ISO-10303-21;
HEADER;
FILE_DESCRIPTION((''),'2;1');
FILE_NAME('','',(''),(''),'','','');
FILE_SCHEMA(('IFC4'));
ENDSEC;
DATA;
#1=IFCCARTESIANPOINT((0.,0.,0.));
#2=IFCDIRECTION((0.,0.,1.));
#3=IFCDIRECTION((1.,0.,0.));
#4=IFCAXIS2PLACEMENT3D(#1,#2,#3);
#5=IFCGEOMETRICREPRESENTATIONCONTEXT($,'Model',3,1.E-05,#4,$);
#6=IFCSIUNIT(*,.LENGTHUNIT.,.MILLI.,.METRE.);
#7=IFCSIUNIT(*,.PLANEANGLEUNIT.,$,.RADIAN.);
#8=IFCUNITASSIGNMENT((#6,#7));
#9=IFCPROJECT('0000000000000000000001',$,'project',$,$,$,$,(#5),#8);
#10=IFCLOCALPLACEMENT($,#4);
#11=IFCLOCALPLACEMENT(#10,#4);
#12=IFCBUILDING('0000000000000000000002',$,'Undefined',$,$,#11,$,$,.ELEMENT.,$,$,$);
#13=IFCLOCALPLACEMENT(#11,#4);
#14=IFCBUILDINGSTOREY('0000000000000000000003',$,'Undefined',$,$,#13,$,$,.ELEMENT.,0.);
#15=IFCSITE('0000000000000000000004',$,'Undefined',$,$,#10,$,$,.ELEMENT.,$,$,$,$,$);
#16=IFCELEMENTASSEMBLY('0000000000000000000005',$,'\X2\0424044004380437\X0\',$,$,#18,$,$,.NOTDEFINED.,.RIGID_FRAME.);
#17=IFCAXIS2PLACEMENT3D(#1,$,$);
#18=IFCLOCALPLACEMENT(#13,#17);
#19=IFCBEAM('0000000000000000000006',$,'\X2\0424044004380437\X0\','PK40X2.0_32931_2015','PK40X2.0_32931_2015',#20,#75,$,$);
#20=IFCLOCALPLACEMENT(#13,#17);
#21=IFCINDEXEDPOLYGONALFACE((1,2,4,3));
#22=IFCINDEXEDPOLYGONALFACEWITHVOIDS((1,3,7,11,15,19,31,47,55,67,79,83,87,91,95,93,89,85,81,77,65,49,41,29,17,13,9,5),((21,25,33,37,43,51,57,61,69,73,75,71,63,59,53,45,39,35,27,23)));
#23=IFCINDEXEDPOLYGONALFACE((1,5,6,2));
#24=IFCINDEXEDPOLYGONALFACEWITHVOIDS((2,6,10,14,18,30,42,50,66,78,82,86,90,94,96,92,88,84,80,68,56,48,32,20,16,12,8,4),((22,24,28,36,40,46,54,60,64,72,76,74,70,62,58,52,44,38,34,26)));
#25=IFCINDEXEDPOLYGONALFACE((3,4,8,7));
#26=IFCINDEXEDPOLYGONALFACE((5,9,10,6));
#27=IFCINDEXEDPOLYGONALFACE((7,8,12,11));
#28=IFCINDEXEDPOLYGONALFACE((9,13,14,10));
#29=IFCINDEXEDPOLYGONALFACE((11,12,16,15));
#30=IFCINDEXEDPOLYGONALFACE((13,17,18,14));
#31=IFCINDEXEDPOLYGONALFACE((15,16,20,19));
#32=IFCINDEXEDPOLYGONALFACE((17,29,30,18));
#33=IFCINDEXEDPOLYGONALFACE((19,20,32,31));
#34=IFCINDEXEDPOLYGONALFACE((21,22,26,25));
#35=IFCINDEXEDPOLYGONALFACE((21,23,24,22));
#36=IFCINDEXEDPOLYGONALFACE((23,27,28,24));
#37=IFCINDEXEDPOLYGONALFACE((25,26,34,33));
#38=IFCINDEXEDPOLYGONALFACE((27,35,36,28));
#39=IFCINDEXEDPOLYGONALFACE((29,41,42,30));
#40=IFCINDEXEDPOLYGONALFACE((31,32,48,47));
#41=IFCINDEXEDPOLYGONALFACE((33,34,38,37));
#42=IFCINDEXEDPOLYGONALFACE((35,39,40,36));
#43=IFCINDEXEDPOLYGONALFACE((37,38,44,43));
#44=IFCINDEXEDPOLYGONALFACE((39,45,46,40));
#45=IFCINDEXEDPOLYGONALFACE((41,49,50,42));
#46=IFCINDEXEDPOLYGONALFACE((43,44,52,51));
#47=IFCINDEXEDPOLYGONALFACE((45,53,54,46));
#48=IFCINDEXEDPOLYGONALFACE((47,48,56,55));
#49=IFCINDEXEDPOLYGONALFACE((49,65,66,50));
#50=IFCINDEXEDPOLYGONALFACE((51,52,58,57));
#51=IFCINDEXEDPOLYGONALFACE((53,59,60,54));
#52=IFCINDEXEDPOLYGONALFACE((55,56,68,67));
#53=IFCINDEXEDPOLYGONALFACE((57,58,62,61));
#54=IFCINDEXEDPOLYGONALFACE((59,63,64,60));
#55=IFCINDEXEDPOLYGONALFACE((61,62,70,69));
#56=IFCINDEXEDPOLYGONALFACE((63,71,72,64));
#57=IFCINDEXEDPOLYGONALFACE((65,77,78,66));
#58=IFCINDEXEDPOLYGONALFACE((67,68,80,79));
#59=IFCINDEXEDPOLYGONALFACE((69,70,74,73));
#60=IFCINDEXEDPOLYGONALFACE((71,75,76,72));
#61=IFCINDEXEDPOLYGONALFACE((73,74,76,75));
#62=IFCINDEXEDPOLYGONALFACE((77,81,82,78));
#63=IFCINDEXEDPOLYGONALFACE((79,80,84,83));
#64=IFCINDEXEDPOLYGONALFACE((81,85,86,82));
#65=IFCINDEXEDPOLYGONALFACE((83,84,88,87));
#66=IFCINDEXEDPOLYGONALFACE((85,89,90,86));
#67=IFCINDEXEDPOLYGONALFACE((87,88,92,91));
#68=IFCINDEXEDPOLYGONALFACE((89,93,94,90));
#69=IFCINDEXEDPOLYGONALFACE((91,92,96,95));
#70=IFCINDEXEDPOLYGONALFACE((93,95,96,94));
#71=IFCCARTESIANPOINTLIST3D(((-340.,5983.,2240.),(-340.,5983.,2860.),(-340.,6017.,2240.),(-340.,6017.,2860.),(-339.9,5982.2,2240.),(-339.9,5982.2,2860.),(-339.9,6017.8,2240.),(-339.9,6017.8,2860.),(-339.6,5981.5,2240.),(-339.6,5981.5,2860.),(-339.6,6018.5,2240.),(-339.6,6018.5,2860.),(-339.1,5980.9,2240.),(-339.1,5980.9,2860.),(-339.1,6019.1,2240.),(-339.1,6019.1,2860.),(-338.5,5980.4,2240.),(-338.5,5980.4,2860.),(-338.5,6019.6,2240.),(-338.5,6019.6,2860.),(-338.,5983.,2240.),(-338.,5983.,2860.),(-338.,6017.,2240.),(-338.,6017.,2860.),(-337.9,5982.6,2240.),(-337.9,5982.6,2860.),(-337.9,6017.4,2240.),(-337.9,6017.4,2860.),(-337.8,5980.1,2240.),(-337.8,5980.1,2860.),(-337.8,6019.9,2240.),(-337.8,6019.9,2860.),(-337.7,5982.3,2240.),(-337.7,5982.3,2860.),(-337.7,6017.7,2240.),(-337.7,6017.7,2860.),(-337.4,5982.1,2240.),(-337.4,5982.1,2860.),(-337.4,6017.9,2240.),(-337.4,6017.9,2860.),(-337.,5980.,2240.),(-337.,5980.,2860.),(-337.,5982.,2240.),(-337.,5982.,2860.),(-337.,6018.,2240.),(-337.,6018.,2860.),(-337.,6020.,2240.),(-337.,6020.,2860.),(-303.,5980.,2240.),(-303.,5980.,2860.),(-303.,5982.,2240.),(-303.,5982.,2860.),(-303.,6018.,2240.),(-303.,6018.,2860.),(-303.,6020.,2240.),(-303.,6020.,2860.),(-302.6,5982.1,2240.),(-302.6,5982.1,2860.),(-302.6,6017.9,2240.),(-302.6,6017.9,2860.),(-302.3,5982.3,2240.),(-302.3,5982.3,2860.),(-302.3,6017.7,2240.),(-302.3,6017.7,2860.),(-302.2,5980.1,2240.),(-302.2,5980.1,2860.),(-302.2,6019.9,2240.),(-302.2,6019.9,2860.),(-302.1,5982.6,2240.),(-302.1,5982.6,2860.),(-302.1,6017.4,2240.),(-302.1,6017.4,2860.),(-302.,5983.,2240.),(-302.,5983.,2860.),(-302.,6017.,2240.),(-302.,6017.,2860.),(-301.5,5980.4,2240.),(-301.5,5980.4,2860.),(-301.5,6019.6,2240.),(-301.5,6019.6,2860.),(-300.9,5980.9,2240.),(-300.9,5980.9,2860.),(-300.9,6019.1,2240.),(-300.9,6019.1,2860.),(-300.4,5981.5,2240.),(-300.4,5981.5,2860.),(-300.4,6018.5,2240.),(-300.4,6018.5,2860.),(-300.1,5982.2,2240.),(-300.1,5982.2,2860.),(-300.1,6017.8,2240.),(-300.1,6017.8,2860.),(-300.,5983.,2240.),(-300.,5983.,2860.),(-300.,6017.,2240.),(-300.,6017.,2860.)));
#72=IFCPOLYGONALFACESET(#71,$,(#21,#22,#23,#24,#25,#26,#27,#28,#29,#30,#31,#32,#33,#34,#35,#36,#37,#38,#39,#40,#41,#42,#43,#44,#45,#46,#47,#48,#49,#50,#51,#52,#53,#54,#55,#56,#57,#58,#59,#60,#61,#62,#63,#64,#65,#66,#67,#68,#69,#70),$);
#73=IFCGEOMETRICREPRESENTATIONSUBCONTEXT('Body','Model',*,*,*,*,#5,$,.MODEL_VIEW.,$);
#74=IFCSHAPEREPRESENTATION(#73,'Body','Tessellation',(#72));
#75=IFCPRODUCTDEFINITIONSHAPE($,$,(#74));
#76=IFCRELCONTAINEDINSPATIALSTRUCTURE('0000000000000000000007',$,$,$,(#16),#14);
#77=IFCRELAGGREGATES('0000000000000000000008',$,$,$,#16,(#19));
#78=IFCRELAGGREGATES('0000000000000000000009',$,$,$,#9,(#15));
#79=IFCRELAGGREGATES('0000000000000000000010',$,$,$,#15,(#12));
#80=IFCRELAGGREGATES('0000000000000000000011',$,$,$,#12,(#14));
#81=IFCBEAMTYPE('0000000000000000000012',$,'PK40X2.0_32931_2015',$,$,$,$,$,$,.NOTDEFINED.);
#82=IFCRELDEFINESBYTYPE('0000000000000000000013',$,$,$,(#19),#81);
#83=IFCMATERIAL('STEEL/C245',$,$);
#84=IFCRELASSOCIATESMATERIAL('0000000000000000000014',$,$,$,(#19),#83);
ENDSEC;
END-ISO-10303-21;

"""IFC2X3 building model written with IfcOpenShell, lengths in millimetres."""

from ifc_helpers import new_model, si_unit, frame, origin_with_axes, origin_2d_with_axis, place, context, subcontext, project, spatial, hollow_rectangle, extrude, material, type_object, element, aggregate, save


model = new_model("IFC2X3")

# Units and contexts
model_context = context("Model", 3, precision=1e-05, world=origin_with_axes())
body_context = subcontext(model_context, "Body", "Model", "MODEL_VIEW")
ifc_project = project(units=[si_unit("LENGTHUNIT", "METRE", prefix="MILLI"), si_unit("PLANEANGLEUNIT", "RADIAN")], contexts=[model_context])

# Site, building, storey
site_placement = place(None, origin_with_axes())
site = spatial("IfcSite", under=ifc_project, at=site_placement, Name="Undefined", CompositionType="ELEMENT")
building_placement = place(site_placement, origin_with_axes())
building = spatial("IfcBuilding", under=site, at=building_placement, Name="Undefined", CompositionType="ELEMENT")
storey_placement = place(building_placement, origin_with_axes())
storey = spatial("IfcBuildingStorey", under=building, at=storey_placement, Name="Undefined", CompositionType="ELEMENT", Elevation=0.0)

# Shared definitions
ifc_material_1 = material(Name="STEEL/C245")

# Element assembly
assembly_1_placement = place(storey_placement, origin_with_axes())
assembly_1 = element("IfcElementAssembly", 1, at=assembly_1_placement, inside=storey, Name="Фриз", AssemblyPlace="NOTDEFINED", PredefinedType="RIGID_FRAME")

# Shared definitions
beam_type_1 = type_object("IfcBeamType", Name="PK40X2.0_32931_2015", PredefinedType="NOTDEFINED")

# Beam
beam_1_placement = place(assembly_1_placement, frame((-320.0, 6000.0, 2860.0), z_axis=(1.0, 0.0, 0.0), x_axis=(0.0, 0.0, -1.0)))
beam_1 = element("IfcBeam", 2, at=beam_1_placement, type_object=beam_type_1, material=ifc_material_1, Name="Фриз", Description="PK40X2.0_32931_2015", ObjectType="PK40X2.0_32931_2015", context=body_context, shape_type="SweptSolid", body=[
    extrude(hollow_rectangle(XDim=40.0, YDim=40.0, WallThickness=2.0, InnerFilletRadius=1.0, OuterFilletRadius=3.0, at=origin_2d_with_axis()), frame((620.0, 0.0, 0.0), z_axis=(-1.0, 0.0, 0.0), x_axis=(0.0, -1.0, 0.0)), (0.0, 0.0, 1.0), 620.0),
])
aggregate(assembly_1, [beam_1])

save(model, "model.ifc")
